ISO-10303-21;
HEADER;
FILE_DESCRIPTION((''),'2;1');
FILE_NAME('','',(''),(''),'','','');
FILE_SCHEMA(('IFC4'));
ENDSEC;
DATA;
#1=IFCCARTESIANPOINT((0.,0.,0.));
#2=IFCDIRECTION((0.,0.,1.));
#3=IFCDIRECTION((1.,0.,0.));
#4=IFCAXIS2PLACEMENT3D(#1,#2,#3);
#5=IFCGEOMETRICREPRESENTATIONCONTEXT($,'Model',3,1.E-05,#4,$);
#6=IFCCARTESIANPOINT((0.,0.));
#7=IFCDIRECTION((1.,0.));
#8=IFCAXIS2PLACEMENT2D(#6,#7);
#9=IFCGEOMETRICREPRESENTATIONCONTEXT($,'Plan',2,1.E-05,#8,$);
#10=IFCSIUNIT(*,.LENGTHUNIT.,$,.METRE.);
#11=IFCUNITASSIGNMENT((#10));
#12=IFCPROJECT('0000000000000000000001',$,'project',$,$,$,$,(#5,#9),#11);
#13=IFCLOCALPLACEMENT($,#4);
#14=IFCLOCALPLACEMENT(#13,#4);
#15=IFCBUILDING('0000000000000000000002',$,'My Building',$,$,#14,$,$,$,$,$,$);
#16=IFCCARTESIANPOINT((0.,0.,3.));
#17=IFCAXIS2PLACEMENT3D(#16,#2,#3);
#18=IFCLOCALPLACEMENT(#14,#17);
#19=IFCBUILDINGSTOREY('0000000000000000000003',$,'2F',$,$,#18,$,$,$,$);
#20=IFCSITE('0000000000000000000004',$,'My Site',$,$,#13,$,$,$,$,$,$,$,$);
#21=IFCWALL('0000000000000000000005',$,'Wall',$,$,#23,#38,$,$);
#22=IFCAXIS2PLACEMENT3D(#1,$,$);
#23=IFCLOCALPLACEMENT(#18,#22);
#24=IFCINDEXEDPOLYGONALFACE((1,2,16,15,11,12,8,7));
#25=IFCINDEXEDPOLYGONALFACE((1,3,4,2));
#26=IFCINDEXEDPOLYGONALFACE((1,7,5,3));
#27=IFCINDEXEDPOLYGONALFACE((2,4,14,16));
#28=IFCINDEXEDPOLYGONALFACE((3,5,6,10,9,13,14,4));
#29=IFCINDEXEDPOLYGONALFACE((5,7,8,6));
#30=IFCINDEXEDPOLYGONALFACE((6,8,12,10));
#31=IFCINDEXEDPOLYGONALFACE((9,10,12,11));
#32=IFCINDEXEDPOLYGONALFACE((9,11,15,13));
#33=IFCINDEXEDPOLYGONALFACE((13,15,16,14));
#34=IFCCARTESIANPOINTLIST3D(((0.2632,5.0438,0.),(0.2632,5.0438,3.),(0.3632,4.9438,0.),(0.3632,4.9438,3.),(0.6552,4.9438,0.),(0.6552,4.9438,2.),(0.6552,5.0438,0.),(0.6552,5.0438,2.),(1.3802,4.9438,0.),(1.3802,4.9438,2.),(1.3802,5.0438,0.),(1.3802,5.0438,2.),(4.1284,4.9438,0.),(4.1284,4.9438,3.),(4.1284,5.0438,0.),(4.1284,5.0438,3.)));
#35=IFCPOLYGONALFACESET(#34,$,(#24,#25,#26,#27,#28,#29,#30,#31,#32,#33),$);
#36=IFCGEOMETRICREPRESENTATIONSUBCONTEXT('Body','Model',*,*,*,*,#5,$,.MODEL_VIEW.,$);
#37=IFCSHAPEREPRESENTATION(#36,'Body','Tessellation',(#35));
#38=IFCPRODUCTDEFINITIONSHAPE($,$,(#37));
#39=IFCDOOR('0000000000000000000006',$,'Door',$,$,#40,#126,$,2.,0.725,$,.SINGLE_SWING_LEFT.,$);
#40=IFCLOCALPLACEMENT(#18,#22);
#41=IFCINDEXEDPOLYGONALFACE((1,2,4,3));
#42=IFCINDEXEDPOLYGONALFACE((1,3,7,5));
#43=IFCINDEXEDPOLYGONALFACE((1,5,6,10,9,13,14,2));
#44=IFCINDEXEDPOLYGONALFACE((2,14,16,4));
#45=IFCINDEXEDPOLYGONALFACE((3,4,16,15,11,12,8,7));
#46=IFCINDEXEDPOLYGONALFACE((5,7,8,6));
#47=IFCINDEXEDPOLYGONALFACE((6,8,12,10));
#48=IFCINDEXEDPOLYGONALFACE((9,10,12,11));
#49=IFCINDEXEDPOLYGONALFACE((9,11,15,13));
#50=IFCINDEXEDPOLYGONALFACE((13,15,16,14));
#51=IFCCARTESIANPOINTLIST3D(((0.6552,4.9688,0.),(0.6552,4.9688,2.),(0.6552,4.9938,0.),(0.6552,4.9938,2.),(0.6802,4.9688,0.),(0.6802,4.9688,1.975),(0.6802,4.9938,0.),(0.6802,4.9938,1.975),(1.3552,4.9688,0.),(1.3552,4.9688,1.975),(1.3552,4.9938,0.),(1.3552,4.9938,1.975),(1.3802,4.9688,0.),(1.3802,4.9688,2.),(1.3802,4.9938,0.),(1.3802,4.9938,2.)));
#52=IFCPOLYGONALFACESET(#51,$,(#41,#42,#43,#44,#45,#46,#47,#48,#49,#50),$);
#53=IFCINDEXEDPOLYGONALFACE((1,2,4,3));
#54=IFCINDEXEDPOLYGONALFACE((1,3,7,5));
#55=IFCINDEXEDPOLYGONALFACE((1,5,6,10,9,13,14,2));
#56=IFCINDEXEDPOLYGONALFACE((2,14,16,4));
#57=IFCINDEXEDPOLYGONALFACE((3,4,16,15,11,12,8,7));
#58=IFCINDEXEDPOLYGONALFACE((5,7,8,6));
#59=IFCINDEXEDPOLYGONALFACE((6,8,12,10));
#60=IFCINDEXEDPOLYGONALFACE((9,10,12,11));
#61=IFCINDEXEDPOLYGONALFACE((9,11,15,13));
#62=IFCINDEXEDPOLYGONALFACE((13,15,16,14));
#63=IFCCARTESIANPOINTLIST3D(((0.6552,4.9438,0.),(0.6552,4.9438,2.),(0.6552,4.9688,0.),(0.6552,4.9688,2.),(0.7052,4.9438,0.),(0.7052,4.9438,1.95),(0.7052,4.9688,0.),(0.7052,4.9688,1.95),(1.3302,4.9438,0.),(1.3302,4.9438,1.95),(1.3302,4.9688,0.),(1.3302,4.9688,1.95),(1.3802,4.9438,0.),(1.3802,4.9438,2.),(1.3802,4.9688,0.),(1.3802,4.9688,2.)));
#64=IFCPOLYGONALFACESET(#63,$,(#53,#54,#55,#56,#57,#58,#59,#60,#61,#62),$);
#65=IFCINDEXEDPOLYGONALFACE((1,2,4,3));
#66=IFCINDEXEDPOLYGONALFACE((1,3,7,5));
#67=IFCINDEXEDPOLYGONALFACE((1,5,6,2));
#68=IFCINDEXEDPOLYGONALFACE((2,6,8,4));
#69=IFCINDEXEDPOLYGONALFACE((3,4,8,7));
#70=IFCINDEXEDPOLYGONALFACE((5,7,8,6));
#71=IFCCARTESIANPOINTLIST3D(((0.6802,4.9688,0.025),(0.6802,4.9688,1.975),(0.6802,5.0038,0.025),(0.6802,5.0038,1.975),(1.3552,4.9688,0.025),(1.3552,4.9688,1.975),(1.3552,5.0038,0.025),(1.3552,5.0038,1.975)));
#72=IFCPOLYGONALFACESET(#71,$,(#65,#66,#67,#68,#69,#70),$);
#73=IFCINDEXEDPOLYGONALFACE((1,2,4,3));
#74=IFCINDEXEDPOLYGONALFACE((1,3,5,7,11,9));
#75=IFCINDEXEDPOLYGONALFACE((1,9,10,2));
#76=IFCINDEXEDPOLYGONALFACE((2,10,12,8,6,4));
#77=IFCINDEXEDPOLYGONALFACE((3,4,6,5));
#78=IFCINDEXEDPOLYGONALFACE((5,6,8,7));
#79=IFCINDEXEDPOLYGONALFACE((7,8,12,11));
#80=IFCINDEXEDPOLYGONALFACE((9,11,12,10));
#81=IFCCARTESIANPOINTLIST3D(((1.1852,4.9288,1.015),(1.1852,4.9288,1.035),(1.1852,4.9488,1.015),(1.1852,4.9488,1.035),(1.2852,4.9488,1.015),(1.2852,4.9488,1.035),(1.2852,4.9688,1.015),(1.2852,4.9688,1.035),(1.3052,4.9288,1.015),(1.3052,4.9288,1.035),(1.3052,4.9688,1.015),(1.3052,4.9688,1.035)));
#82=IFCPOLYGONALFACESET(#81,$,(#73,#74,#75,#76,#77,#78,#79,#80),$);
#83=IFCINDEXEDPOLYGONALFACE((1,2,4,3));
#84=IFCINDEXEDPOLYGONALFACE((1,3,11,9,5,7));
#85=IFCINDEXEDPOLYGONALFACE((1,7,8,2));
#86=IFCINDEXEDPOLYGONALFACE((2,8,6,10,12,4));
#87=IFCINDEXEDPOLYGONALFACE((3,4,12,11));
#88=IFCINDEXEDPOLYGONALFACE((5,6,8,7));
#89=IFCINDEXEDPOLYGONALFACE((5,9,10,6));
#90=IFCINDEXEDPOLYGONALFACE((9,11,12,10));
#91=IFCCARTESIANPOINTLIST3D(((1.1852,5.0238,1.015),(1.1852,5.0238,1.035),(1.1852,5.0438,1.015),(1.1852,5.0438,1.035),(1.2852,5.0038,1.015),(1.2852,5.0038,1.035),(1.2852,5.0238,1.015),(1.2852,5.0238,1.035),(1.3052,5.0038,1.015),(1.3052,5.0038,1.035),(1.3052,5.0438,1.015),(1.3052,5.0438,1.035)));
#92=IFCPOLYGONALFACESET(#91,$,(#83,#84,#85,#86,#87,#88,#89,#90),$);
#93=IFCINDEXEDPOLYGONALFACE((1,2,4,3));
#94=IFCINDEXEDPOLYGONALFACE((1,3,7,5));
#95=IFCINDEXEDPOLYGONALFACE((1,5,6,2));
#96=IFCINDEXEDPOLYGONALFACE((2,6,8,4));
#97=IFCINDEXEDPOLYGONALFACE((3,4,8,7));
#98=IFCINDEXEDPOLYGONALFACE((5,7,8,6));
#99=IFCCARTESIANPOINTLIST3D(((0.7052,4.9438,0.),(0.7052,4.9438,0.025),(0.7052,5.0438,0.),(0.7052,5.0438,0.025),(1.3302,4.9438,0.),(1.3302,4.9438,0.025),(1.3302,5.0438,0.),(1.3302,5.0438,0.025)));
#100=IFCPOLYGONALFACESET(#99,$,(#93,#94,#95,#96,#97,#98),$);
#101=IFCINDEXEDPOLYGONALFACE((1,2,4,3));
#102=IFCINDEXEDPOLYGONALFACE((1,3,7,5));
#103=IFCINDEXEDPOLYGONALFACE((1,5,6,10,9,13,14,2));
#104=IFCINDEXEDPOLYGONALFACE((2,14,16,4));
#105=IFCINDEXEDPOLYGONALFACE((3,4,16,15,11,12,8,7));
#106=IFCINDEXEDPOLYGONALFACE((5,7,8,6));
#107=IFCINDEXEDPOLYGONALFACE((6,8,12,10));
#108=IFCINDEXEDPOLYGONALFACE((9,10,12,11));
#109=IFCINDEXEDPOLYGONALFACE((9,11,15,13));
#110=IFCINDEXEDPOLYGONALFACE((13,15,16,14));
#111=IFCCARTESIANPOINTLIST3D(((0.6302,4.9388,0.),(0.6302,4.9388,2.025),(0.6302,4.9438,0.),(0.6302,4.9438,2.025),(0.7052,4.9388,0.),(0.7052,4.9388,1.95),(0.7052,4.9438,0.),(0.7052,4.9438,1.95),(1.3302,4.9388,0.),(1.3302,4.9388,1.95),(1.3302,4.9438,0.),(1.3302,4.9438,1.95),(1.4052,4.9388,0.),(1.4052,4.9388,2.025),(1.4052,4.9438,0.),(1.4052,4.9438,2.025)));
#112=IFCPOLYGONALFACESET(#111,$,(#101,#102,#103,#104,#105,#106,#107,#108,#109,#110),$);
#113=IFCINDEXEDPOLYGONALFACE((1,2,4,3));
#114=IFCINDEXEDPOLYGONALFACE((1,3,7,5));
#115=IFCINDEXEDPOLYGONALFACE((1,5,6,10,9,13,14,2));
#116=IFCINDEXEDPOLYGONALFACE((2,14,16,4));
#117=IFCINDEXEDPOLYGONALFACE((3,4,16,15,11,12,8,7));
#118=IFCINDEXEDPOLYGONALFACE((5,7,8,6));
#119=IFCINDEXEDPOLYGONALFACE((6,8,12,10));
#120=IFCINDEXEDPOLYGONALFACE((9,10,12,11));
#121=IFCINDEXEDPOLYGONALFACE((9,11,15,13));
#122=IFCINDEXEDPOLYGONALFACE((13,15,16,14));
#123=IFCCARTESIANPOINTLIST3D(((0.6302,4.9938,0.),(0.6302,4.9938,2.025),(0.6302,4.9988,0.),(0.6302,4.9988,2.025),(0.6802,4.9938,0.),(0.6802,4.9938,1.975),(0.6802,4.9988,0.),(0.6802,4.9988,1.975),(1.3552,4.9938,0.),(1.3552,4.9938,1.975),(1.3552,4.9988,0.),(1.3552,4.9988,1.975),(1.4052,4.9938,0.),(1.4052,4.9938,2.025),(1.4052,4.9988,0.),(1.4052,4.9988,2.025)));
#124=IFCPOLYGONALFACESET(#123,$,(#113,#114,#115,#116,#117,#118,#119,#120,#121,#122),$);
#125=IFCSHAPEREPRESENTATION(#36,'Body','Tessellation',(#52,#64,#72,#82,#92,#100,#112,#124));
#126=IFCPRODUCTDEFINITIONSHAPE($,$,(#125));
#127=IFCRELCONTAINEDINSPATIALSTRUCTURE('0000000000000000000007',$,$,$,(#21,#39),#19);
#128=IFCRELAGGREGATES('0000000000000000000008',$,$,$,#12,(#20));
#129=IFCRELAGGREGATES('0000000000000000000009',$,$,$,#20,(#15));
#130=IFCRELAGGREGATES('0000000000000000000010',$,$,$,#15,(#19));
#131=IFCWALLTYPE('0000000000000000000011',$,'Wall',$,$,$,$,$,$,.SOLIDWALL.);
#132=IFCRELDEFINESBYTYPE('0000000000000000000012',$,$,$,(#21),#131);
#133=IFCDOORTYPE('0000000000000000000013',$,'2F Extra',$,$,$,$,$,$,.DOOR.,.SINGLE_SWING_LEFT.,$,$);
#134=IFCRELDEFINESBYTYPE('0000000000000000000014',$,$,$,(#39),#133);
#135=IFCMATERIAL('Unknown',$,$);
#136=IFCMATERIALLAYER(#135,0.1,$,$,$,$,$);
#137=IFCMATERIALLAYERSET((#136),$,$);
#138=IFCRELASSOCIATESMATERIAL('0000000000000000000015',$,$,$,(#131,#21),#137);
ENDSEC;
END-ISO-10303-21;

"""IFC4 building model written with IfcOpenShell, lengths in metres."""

from ifc_helpers import new_model, entity, si_unit, frame, origin_with_axes, origin_2d_with_axis, place, context, subcontext, project, spatial, line, indexed_curve, outline, extrude, shape, source, transform, mapped, material, layer, layer_set, layer_usage, type_object, type_shapes, element, fill, save


model = new_model("IFC4")

# Units and contexts
model_context_1 = context("Model", 3, precision=1e-05, world=origin_with_axes())
plan_context = context("Plan", 2, precision=1e-05, world=origin_2d_with_axis())
body_context_1 = subcontext(model_context_1, "Body", "Model", "MODEL_VIEW")
body_context_2 = subcontext(plan_context, "Body", "Plan", "PLAN_VIEW")
ifc_project = project(units=[si_unit("LENGTHUNIT", "METRE")], contexts=[model_context_1, plan_context])

# Site, building, storey
site_placement = place(None, origin_with_axes())
site = spatial("IfcSite", under=ifc_project, at=site_placement, Name="My Site")
building_placement = place(site_placement, origin_with_axes())
building = spatial("IfcBuilding", under=site, at=building_placement, Name="My Building")
storey_placement = place(building_placement, frame((0.0, 0.0, 3.0), z_axis=(0.0, 0.0, 1.0), x_axis=(1.0, 0.0, 0.0)))
storey = spatial("IfcBuildingStorey", under=building, at=storey_placement, Name="2F")

# Shared definitions
ifc_material = material(Name="Unknown")

# Shared definitions
ifc_layer_1 = layer(ifc_material, 0.1)
ifc_layer_set_1 = layer_set([ifc_layer_1])
wall_type = type_object("IfcWallType", Name="Wall", PredefinedType="SOLIDWALL", material=ifc_layer_set_1)

# Wall, opening, door
ifc_layer_usage_1 = layer_usage(ifc_layer_set_1, "AXIS2", "POSITIVE", 0.0)
wall_1_placement = place(storey_placement, frame((4.1284, 5.0438, 0.0), z_axis=(0.0, 0.0, 1.0), x_axis=(-1.0, 0.0, 0.0)))
wall_1 = element("IfcWall", 1, at=wall_1_placement, inside=storey, type_object=wall_type, material=ifc_layer_usage_1, Name="Wall", context=body_context_1, shape_type="SweptSolid", body=[
    extrude(outline(indexed_curve([(0.0, 0.0), (0.0, 0.1), (3.7652, 0.1), (3.8652, 0.0)], segments=[line(1, 2, 3, 4, 1)])), origin_with_axes(), (0.0, 0.0, 1.0), 3.0),
])
shared_shape_1 = source(origin_with_axes(), body_context_1, "Body", "SweptSolid", [
    extrude(outline(indexed_curve([(0.0, 0.0), (0.725, 0.0), (0.725, 2.0), (0.0, 2.0)], segments=[line(1, 2, 3, 4, 1)])), frame((0.0, -0.6, 0.0), z_axis=(0.0, -1.0, 0.0), x_axis=(1.0, 0.0, 0.0)), (0.0, 0.0, -1.0), 1.2),
])
opening_1_placement = place(wall_1_placement, frame((3.4732, 0.1, 0.0), z_axis=(0.0, 0.0, 1.0), x_axis=(-1.0, 0.0, 0.0)))
opening_1 = element("IfcOpeningElement", 2, at=opening_1_placement, cuts=wall_1, PredefinedType="OPENING", context=body_context_1, shape_type="MappedRepresentation", body=[
    mapped(shared_shape_1, transform((0.0, 0.0, 0.0), x_axis=(1.0, 0.0, 0.0), y_axis=(0.0, 1.0, 0.0), z_axis=(0.0, 0.0, 1.0), scale=1.0)),
])
door_type_1 = type_object("IfcDoorType", Name="2F Extra", OperationType="SINGLE_SWING_LEFT", PredefinedType="DOOR")
shared_shape_2 = source(origin_with_axes(), body_context_1, "Body", "SweptSolid", [
    extrude(outline(indexed_curve([(0.0, 0.0), (0.0, 2.0), (0.725, 2.0), (0.725, 0.0), (0.7, 0.0), (0.7, 1.975), (0.025, 1.975), (0.025, 0.0)], segments=[line(1, 2, 3, 4, 5, 6, 7, 8, 1)])), frame((0.0, 0.025, 0.0), z_axis=(0.0, -1.0, 0.0), x_axis=(1.0, 0.0, 0.0)), (0.0, 0.0, -1.0), 0.025),
    extrude(outline(indexed_curve([(0.0, 0.0), (0.0, 2.0), (0.725, 2.0), (0.725, 0.0), (0.675, 0.0), (0.675, 1.95), (0.05, 1.95), (0.05, 0.0)], segments=[line(1, 2, 3, 4, 5, 6, 7, 8, 1)])), frame((0.0, 0.0, 0.0), z_axis=(0.0, -1.0, 0.0), x_axis=(1.0, 0.0, 0.0)), (0.0, 0.0, -1.0), 0.025),
    extrude(outline(indexed_curve([(0.0, 0.0), (0.675, 0.0), (0.675, 0.035), (0.0, 0.035)], segments=[line(1, 2, 3, 4, 1)])), frame((0.025, 0.025, 0.025), z_axis=(0.0, 0.0, 1.0), x_axis=(1.0, 0.0, 0.0)), (0.0, 0.0, 1.0), 1.95),
    extrude(outline(indexed_curve([(0.0, 0.0), (0.0, -0.04), (-0.12, -0.04), (-0.12, -0.02), (-0.02, -0.02), (-0.02, 0.0)], segments=[line(1, 2, 3, 4, 5, 6, 1)])), frame((0.65, 0.025, 1.015), z_axis=(0.0, 0.0, 1.0), x_axis=(1.0, 0.0, 0.0)), (0.0, 0.0, 1.0), 0.02),
    extrude(outline(indexed_curve([(0.0, 0.0), (0.0, 0.04), (-0.12, 0.04), (-0.12, 0.02), (-0.02, 0.02), (-0.02, 0.0)], segments=[line(1, 2, 3, 4, 5, 6, 1)])), frame((0.65, 0.06, 1.015), z_axis=(0.0, 0.0, 1.0), x_axis=(1.0, 0.0, 0.0)), (0.0, 0.0, 1.0), 0.02),
    extrude(outline(indexed_curve([(0.0, 0.0), (0.625, 0.0), (0.625, 0.1), (0.0, 0.1)], segments=[line(1, 2, 3, 4, 1)])), frame((0.05, 0.0, 0.0), z_axis=(0.0, 0.0, 1.0), x_axis=(1.0, 0.0, 0.0)), (0.0, 0.0, 1.0), 0.025),
    extrude(outline(indexed_curve([(0.0, 0.0), (0.0, 2.025), (0.775, 2.025), (0.775, 0.0), (0.7, 0.0), (0.7, 1.95), (0.075, 1.95), (0.075, 0.0)], segments=[line(1, 2, 3, 4, 5, 6, 7, 8, 1)])), frame((-0.025, -0.005, 0.0), z_axis=(0.0, -1.0, 0.0), x_axis=(1.0, 0.0, 0.0)), (0.0, 0.0, -1.0), 0.005),
    extrude(outline(indexed_curve([(0.0, 0.0), (0.0, 2.025), (0.775, 2.025), (0.775, 0.0), (0.725, 0.0), (0.725, 1.975), (0.05, 1.975), (0.05, 0.0)], segments=[line(1, 2, 3, 4, 5, 6, 7, 8, 1)])), frame((-0.025, 0.05, 0.0), z_axis=(0.0, -1.0, 0.0), x_axis=(1.0, 0.0, 0.0)), (0.0, 0.0, -1.0), 0.005),
])
shared_shape_3 = source(origin_with_axes(), body_context_2, "Body", "Curve2D", [
    entity("IfcIndexedPolyCurve", entity("IfcCartesianPointList2D", [[0.0, 0.0], [0.0, 0.05], [0.025, 0.05], [0.025, 0.025], [0.05, 0.025], [0.05, 0.0]]), [entity("IfcLineIndex", [1, 2, 3, 4, 5, 6, 1])]),
    entity("IfcIndexedPolyCurve", entity("IfcCartesianPointList2D", [[0.725, 0.0], [0.725, 0.05], [0.7, 0.05], [0.7, 0.025], [0.675, 0.025], [0.675, 0.0]]), [entity("IfcLineIndex", [1, 2, 3, 4, 5, 6, 1])]),
    entity("IfcTrimmedCurve", entity("IfcEllipse", entity("IfcAxis2Placement2D", entity("IfcCartesianPoint", [0.06, 0.05]), entity("IfcDirection", [1.0, 0.0])), 0.64, 0.675), [entity("IfcCartesianPoint", [0.7, 0.05])], [entity("IfcCartesianPoint", [0.06, 0.725])], True, "CARTESIAN"),
    entity("IfcIndexedPolyCurve", entity("IfcCartesianPointList2D", [[0.025, 0.05], [0.06, 0.05], [0.06, 0.725], [0.025, 0.725]]), [entity("IfcLineIndex", [1, 2, 3, 4, 1])]),
])
type_shapes(door_type_1, [shared_shape_2, shared_shape_3])
door_1_placement = place(opening_1_placement, frame((0.0, 0.0, 0.0), z_axis=(0.0, 0.0, 1.0), x_axis=(1.0, 0.0, 0.0)))
door_1 = element("IfcDoor", 3, at=door_1_placement, inside=storey, type_object=door_type_1, Name="Door", OperationType="SINGLE_SWING_LEFT", OverallHeight=2.0, OverallWidth=0.725, shapes=[
    shape(body_context_1, "Body", "MappedRepresentation", [mapped(shared_shape_2, transform((0.0, 0.0, 0.0), x_axis=(1.0, 0.0, 0.0), y_axis=(0.0, 1.0, 0.0), z_axis=(0.0, 0.0, 1.0), scale=1.0))]),
    shape(body_context_2, "Body", "MappedRepresentation", [mapped(shared_shape_3, transform((0.0, 0.0, 0.0), x_axis=(1.0, 0.0, 0.0), y_axis=(0.0, 1.0, 0.0), z_axis=(0.0, 0.0, 1.0), scale=1.0))]),
])
fill(opening_1, door_1)

save(model, "model.ifc")
